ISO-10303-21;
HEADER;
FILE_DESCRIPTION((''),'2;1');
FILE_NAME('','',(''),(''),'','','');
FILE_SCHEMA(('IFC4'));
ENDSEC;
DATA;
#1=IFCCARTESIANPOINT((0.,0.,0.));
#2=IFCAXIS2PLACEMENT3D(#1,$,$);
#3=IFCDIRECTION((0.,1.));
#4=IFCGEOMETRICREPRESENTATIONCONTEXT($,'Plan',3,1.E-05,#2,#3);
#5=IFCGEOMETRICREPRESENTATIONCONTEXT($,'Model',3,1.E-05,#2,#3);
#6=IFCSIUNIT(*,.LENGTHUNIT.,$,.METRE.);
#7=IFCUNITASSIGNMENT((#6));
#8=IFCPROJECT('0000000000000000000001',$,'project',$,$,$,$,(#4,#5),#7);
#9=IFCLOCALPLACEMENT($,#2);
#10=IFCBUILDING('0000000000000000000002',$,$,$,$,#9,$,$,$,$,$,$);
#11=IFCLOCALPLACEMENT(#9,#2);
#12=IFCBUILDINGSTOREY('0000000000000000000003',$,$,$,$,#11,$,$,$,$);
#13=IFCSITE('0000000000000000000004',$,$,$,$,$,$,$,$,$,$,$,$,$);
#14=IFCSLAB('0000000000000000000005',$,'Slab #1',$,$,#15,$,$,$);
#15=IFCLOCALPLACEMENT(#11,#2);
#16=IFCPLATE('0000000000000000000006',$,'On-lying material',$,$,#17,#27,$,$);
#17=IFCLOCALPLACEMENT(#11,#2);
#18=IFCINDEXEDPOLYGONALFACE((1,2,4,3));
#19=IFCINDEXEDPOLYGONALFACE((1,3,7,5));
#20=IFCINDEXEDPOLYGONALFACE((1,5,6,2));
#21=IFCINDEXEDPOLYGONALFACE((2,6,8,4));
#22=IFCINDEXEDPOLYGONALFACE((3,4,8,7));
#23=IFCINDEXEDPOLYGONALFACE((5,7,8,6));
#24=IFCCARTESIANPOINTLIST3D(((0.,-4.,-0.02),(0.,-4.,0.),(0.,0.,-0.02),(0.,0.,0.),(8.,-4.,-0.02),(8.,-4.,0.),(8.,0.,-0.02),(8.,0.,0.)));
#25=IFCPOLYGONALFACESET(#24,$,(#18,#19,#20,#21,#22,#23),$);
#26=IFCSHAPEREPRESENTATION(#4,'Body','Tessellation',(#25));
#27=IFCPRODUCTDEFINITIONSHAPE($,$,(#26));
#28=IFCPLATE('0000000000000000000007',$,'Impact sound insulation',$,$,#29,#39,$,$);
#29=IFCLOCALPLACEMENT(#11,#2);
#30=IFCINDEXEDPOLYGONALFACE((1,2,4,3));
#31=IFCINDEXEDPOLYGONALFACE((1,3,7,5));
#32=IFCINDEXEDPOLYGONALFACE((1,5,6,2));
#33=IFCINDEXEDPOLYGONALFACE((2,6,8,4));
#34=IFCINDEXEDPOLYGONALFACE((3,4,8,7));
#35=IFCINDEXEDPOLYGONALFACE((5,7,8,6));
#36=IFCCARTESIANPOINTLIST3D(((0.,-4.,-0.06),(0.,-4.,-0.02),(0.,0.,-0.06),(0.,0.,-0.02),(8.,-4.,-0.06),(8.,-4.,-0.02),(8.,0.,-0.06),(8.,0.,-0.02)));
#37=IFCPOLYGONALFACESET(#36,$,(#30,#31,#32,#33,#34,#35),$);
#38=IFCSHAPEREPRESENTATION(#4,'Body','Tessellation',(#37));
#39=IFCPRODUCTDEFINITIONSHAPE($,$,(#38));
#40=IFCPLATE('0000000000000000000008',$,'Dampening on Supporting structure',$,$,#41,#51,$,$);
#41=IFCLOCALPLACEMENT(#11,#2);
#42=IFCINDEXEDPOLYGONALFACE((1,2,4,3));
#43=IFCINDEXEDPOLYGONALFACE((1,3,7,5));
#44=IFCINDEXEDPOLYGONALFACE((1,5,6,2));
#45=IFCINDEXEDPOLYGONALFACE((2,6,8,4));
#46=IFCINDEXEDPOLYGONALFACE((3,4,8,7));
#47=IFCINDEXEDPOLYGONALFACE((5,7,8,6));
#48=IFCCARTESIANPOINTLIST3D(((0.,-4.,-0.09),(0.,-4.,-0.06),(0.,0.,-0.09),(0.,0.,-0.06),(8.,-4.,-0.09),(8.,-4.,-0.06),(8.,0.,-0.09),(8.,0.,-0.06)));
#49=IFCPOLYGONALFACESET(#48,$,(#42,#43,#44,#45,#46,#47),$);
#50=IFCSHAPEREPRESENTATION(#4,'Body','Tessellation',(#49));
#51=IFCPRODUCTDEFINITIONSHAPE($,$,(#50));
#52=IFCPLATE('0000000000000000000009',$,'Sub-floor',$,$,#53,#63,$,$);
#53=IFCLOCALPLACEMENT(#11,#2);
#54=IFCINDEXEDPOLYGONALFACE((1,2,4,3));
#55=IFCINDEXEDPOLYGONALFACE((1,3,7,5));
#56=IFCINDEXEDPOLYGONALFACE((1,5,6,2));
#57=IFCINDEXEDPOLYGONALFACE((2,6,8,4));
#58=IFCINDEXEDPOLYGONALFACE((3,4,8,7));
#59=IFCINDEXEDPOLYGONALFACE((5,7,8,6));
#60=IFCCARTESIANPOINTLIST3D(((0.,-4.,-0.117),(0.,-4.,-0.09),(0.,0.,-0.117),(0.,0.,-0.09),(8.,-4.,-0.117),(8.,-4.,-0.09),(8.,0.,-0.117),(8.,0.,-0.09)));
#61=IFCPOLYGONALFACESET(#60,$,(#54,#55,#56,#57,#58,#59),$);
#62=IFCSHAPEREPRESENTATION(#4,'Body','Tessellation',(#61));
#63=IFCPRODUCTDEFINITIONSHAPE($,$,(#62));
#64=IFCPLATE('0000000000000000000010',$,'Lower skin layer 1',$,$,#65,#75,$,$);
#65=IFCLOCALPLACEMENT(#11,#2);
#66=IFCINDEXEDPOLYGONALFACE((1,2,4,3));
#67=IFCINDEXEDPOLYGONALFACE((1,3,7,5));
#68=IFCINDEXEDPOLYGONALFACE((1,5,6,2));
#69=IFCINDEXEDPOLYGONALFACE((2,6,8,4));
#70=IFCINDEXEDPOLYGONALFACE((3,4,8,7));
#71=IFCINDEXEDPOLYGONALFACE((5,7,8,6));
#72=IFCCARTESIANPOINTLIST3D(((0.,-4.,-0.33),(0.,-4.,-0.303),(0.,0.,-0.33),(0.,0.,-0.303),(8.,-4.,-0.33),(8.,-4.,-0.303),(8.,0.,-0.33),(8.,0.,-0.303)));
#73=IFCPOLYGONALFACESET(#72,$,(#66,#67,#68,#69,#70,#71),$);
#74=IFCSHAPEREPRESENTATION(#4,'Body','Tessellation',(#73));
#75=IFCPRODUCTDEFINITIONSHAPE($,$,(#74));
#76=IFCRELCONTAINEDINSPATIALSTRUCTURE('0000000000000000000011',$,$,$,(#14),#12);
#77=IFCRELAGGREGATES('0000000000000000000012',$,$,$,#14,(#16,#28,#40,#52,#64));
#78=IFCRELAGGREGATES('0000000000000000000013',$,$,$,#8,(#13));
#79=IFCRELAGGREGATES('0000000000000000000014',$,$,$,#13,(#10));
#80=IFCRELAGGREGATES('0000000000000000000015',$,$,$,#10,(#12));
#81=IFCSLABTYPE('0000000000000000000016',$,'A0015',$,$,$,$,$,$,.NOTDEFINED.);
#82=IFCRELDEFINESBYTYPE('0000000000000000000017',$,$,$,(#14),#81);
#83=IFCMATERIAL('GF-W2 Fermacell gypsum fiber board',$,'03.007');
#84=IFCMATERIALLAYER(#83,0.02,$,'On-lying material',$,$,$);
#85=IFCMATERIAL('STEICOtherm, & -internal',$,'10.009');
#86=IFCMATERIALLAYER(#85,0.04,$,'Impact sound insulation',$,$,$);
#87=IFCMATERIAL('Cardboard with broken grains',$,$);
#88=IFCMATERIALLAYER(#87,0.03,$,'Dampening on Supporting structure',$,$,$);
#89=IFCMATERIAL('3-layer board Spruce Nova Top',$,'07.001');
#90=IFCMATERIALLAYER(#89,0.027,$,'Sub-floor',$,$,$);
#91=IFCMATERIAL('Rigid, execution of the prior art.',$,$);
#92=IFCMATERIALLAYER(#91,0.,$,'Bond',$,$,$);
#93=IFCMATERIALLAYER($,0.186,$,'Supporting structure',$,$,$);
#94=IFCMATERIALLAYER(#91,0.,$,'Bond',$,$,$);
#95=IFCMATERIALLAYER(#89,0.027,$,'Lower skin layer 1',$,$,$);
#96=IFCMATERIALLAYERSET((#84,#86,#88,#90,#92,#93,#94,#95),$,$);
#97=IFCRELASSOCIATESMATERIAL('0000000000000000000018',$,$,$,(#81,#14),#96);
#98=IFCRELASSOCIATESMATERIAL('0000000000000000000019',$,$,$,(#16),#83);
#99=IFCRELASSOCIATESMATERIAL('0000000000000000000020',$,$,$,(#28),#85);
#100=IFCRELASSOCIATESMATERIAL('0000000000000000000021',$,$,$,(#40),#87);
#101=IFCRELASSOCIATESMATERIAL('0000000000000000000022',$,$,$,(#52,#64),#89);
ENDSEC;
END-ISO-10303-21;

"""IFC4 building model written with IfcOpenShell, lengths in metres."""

from ifc_helpers import new_model, si_unit, direction, frame, frame_2d, origin, origin_with_axes, place, context, project, spatial, rectangle, extrude, material, layer, layer_set, type_object, element, aggregate, save


model = new_model("IFC4")

# Units and contexts
plan_context = context("Plan", 3, precision=1e-05, world=origin(), true_north=direction((0.0, 1.0)))
model_context = context("Model", 3, precision=1e-05, world=origin(), true_north=direction((0.0, 1.0)))
ifc_project = project(units=[si_unit("LENGTHUNIT", "METRE")], contexts=[plan_context, model_context])

# Site, building, storey
site = spatial("IfcSite", under=ifc_project)
building_placement = place(None, origin())
building = spatial("IfcBuilding", under=site, at=building_placement)
storey_placement = place(building_placement, origin())
storey = spatial("IfcBuildingStorey", under=building, at=storey_placement)

# Slab, plates
ifc_material_1 = material(Name="GF-W2 Fermacell gypsum fiber board", Category="03.007")
ifc_layer_1 = layer(ifc_material_1, 0.02, Name="On-lying material")
ifc_material_2 = material(Name="STEICOtherm, & -internal", Category="10.009")
ifc_layer_2 = layer(ifc_material_2, 0.04, Name="Impact sound insulation")
ifc_material_3 = material(Name="Cardboard with broken grains")
ifc_layer_3 = layer(ifc_material_3, 0.03, Name="Dampening on Supporting structure")
ifc_material_4 = material(Name="3-layer board Spruce Nova Top", Category="07.001")
ifc_layer_4 = layer(ifc_material_4, 0.027, Name="Sub-floor")
ifc_material_5 = material(Name="Rigid, execution of the prior art.")
ifc_layer_5 = layer(ifc_material_5, 0.0, Name="Bond")
ifc_layer_6 = layer(None, 0.186, Name="Supporting structure")
ifc_layer_7 = layer(ifc_material_5, 0.0, Name="Bond")
ifc_layer_8 = layer(ifc_material_4, 0.027, Name="Lower skin layer 1")
ifc_layer_set = layer_set([ifc_layer_1, ifc_layer_2, ifc_layer_3, ifc_layer_4, ifc_layer_5, ifc_layer_6, ifc_layer_7, ifc_layer_8])
slab_type = type_object("IfcSlabType", Name="A0015", PredefinedType="NOTDEFINED", material=ifc_layer_set)
slab_placement = place(None, frame((0.0, 0.0, 0.0), z_axis=(0.0, 0.0, -1.0), x_axis=(1.0, 0.0, 0.0)))
slab = element("IfcSlab", 1, at=slab_placement, inside=storey, type_object=slab_type, material=ifc_layer_set, Name="Slab #1")
plate_1_placement = place(slab_placement, origin())
plate_1 = element("IfcPlate", 2, at=plate_1_placement, material=ifc_material_1, Name="On-lying material", context=plan_context, shape_type="SweptSolid", body=[
    extrude(rectangle(XDim=8.0, YDim=4.0, at=frame_2d((4.0, 2.0), x_axis=(1.0, 0.0))), origin_with_axes(), (0.0, 0.0, 1.0), 0.02),
])
plate_2_placement = place(slab_placement, origin())
plate_2 = element("IfcPlate", 3, at=plate_2_placement, material=ifc_material_2, Name="Impact sound insulation", context=plan_context, shape_type="SweptSolid", body=[
    extrude(rectangle(XDim=8.0, YDim=4.0, at=frame_2d((4.0, 2.0), x_axis=(1.0, 0.0))), frame((0.0, 0.0, 0.02), z_axis=(0.0, 0.0, 1.0), x_axis=(1.0, 0.0, 0.0)), (0.0, 0.0, 1.0), 0.04),
])
plate_3_placement = place(slab_placement, origin())
plate_3 = element("IfcPlate", 4, at=plate_3_placement, material=ifc_material_3, Name="Dampening on Supporting structure", context=plan_context, shape_type="SweptSolid", body=[
    extrude(rectangle(XDim=8.0, YDim=4.0, at=frame_2d((4.0, 2.0), x_axis=(1.0, 0.0))), frame((0.0, 0.0, 0.06), z_axis=(0.0, 0.0, 1.0), x_axis=(1.0, 0.0, 0.0)), (0.0, 0.0, 1.0), 0.03),
])
plate_4_placement = place(slab_placement, origin())
plate_4 = element("IfcPlate", 5, at=plate_4_placement, material=ifc_material_4, Name="Sub-floor", context=plan_context, shape_type="SweptSolid", body=[
    extrude(rectangle(XDim=8.0, YDim=4.0, at=frame_2d((4.0, 2.0), x_axis=(1.0, 0.0))), frame((0.0, 0.0, 0.09), z_axis=(0.0, 0.0, 1.0), x_axis=(1.0, 0.0, 0.0)), (0.0, 0.0, 1.0), 0.027),
])
plate_5_placement = place(slab_placement, origin())
plate_5 = element("IfcPlate", 6, at=plate_5_placement, material=ifc_material_4, Name="Lower skin layer 1", context=plan_context, shape_type="SweptSolid", body=[
    extrude(rectangle(XDim=8.0, YDim=4.0, at=frame_2d((4.0, 2.0), x_axis=(1.0, 0.0))), frame((0.0, 0.0, 0.303), z_axis=(0.0, 0.0, 1.0), x_axis=(1.0, 0.0, 0.0)), (0.0, 0.0, 1.0), 0.027),
])
aggregate(slab, [plate_1, plate_2, plate_3, plate_4, plate_5])

save(model, "model.ifc")
